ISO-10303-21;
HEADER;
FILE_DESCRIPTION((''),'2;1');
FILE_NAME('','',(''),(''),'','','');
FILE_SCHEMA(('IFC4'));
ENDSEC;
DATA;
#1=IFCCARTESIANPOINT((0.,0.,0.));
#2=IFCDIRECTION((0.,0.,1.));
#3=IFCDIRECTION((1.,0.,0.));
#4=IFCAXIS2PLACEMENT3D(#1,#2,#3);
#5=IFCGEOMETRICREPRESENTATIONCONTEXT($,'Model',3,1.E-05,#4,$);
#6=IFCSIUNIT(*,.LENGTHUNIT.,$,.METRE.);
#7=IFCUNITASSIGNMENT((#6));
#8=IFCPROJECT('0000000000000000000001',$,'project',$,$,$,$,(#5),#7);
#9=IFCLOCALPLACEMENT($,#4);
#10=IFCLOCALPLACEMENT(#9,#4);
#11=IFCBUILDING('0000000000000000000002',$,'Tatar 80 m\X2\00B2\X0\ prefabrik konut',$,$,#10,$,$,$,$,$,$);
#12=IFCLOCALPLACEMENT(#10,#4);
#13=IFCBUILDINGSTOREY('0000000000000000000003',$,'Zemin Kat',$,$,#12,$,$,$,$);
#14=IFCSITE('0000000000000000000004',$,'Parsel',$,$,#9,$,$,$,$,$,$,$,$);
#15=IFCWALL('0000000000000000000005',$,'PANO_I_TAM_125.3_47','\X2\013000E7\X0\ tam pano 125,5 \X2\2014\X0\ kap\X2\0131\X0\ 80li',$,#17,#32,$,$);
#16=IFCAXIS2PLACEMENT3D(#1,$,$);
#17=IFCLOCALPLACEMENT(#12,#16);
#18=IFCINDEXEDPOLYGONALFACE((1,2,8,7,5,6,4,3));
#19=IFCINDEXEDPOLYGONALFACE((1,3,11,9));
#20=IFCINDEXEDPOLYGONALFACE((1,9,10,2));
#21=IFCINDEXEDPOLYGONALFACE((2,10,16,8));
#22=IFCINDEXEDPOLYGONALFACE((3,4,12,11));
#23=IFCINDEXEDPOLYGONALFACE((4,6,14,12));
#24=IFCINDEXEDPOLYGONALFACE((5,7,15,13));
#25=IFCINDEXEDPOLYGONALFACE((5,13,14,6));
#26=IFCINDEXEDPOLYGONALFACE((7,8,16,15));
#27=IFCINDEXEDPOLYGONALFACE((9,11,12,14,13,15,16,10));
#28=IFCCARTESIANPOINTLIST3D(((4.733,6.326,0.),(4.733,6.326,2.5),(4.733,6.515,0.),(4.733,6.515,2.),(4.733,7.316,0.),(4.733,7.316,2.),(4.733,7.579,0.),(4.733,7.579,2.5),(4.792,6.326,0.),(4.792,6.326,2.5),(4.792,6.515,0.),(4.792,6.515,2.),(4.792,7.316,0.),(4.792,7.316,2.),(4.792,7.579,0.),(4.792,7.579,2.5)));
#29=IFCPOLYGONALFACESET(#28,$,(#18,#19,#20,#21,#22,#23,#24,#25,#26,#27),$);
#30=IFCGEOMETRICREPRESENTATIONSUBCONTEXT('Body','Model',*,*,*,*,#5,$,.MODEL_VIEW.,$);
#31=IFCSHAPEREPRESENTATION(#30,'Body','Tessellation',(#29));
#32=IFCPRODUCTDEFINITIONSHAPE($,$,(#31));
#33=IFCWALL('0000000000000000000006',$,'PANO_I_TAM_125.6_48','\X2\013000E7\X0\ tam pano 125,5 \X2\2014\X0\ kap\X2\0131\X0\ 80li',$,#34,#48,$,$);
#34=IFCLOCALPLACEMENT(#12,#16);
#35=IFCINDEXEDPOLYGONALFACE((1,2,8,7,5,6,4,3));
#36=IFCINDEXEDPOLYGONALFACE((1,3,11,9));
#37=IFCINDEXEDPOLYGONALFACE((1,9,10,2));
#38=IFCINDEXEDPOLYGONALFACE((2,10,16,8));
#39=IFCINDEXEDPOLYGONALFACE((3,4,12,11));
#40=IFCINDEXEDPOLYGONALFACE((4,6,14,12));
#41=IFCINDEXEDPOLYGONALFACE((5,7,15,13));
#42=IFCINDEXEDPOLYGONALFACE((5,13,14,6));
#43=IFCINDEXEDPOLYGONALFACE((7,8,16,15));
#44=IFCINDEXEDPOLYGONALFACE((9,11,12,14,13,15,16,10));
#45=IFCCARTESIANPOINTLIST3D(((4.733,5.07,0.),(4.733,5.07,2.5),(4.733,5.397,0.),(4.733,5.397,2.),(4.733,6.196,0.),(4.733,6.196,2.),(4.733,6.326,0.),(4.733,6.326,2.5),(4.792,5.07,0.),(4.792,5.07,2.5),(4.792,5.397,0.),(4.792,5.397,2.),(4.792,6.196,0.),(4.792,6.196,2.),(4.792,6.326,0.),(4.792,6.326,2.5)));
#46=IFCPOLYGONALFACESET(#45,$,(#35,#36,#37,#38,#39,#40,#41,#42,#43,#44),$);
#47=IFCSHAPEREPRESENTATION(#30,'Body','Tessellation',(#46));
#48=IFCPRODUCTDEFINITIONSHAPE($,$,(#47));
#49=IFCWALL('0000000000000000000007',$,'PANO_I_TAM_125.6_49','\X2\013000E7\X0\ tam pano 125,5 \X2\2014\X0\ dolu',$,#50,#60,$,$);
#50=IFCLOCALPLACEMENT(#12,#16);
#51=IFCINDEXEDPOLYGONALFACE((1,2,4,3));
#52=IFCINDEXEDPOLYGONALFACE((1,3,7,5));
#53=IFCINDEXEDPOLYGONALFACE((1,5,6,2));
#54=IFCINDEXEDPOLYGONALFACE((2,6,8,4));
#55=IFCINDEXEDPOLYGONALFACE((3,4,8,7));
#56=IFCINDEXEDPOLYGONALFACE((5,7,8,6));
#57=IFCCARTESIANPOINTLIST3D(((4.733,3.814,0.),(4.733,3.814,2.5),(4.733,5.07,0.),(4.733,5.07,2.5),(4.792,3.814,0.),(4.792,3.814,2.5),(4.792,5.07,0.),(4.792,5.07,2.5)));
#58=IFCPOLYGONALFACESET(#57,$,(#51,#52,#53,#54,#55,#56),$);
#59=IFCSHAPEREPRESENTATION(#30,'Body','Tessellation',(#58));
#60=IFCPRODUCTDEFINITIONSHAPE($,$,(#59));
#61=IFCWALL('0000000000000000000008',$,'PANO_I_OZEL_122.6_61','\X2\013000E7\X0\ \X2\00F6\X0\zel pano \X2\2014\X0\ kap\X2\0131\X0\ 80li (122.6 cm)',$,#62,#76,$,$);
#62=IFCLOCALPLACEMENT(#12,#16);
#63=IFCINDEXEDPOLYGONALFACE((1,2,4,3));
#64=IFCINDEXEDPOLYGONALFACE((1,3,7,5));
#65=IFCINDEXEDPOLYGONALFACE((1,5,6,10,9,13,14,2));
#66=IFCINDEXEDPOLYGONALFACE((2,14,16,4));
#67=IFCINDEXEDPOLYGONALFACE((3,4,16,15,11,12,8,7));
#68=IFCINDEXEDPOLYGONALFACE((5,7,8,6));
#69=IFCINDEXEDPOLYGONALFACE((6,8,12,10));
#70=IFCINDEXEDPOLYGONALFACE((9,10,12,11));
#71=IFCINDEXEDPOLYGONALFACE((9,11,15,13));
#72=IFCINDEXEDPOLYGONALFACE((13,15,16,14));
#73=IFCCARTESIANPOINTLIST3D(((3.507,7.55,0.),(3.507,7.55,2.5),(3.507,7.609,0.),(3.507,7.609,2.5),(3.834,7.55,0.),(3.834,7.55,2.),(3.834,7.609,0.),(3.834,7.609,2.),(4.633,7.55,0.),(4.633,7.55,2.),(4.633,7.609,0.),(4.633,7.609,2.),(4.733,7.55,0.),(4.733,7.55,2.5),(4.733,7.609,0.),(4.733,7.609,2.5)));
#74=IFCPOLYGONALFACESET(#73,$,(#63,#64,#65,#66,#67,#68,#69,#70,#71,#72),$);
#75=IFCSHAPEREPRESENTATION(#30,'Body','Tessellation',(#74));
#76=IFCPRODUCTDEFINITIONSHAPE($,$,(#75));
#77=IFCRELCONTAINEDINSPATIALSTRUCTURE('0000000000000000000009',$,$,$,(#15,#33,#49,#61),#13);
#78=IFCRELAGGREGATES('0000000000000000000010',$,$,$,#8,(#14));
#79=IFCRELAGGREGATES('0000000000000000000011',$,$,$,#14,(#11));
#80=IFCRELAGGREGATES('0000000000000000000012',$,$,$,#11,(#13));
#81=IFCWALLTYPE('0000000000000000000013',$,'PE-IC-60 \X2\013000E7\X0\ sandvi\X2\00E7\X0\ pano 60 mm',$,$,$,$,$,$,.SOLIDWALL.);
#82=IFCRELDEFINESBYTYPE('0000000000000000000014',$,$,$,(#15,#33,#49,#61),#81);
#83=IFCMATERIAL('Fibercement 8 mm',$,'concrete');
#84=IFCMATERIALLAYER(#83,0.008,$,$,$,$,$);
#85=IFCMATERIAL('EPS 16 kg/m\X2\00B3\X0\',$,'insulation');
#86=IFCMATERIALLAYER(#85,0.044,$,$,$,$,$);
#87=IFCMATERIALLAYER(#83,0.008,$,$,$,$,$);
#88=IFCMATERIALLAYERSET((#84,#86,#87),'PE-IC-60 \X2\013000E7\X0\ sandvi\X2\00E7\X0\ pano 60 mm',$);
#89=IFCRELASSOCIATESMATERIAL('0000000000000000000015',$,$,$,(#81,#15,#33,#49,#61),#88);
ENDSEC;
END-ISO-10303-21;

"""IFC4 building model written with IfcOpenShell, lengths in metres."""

from ifc_helpers import new_model, si_unit, frame, origin_with_axes, place, context, subcontext, project, spatial, line, indexed_curve, outline, extrude, material, layer, layer_set, layer_usage, type_object, element, save


model = new_model("IFC4")

# Units and contexts
model_context = context("Model", 3, precision=1e-05, world=origin_with_axes())
body_context = subcontext(model_context, "Body", "Model", "MODEL_VIEW")
ifc_project = project(units=[si_unit("LENGTHUNIT", "METRE")], contexts=[model_context])

# Site, building, storey
site_placement = place(None, origin_with_axes())
site = spatial("IfcSite", under=ifc_project, at=site_placement, Name="Parsel")
building_placement = place(site_placement, origin_with_axes())
building = spatial("IfcBuilding", under=site, at=building_placement, Name="Tatar 80 m² prefabrik konut")
storey_placement = place(building_placement, origin_with_axes())
storey = spatial("IfcBuildingStorey", under=building, at=storey_placement, Name="Zemin Kat")

# Shared definitions
ifc_material_1 = material(Name="Fibercement 8 mm", Category="concrete")
ifc_material_2 = material(Name="EPS 16 kg/m³", Category="insulation")

# Shared definitions
ifc_layer_1 = layer(ifc_material_1, 0.008)
ifc_layer_2 = layer(ifc_material_2, 0.044)
ifc_layer_3 = layer(ifc_material_1, 0.008)
ifc_layer_set_1 = layer_set([ifc_layer_1, ifc_layer_2, ifc_layer_3], Name="PE-IC-60 İç sandviç pano 60 mm")
wall_type_1 = type_object("IfcWallType", Name="PE-IC-60 İç sandviç pano 60 mm", PredefinedType="SOLIDWALL", material=ifc_layer_set_1)

# Walls, openings
ifc_layer_usage_1 = layer_usage(ifc_layer_set_1, "AXIS2", "POSITIVE", 0.0)
wall_1_placement = place(storey_placement, frame((4.792, 6.326, 0.0), z_axis=(0.0, 0.0, 1.0), x_axis=(0.0, 1.0, 0.0)))
wall_1 = element("IfcWall", 1, at=wall_1_placement, inside=storey, type_object=wall_type_1, material=ifc_layer_usage_1, Name="PANO_I_TAM_125.3_47", Description="İç tam pano 125,5 — kapı 80li", context=body_context, shape_type="SweptSolid", body=[
    extrude(outline(indexed_curve([(0.0, 0.0), (1.253, 0.0), (1.253, 0.059), (0.0, 0.059)], segments=[line(1, 2, 3, 4, 1)])), origin_with_axes(), (0.0, 0.0, 1.0), 2.5),
])
opening_1_placement = place(wall_1_placement, origin_with_axes())
element("IfcOpeningElement", 2, at=opening_1_placement, cuts=wall_1, PredefinedType="OPENING", context=body_context, shape_type="SweptSolid", body=[
    extrude(outline(indexed_curve([(0.0, 0.0), (0.801, 0.0), (0.801, 0.099), (0.0, 0.099)], segments=[line(1, 2, 3, 4, 1)])), frame((0.189, -0.02, 0.0), z_axis=(0.0, 0.0, 1.0), x_axis=(1.0, 0.0, 0.0)), (0.0, 0.0, 1.0), 2.0),
])
ifc_layer_usage_2 = layer_usage(ifc_layer_set_1, "AXIS2", "POSITIVE", 0.0)
wall_2_placement = place(storey_placement, frame((4.792, 5.07, 0.0), z_axis=(0.0, 0.0, 1.0), x_axis=(0.0, 1.0, 0.0)))
wall_2 = element("IfcWall", 3, at=wall_2_placement, inside=storey, type_object=wall_type_1, material=ifc_layer_usage_2, Name="PANO_I_TAM_125.6_48", Description="İç tam pano 125,5 — kapı 80li", context=body_context, shape_type="SweptSolid", body=[
    extrude(outline(indexed_curve([(0.0, 0.0), (1.256, 0.0), (1.256, 0.059), (0.0, 0.059)], segments=[line(1, 2, 3, 4, 1)])), origin_with_axes(), (0.0, 0.0, 1.0), 2.5),
])
opening_2_placement = place(wall_2_placement, origin_with_axes())
element("IfcOpeningElement", 4, at=opening_2_placement, cuts=wall_2, PredefinedType="OPENING", context=body_context, shape_type="SweptSolid", body=[
    extrude(outline(indexed_curve([(0.0, 0.0), (0.799, 0.0), (0.799, 0.099), (0.0, 0.099)], segments=[line(1, 2, 3, 4, 1)])), frame((0.327, -0.02, 0.0), z_axis=(0.0, 0.0, 1.0), x_axis=(1.0, 0.0, 0.0)), (0.0, 0.0, 1.0), 2.0),
])

# Wall
ifc_layer_usage_3 = layer_usage(ifc_layer_set_1, "AXIS2", "POSITIVE", 0.0)
wall_3_placement = place(storey_placement, frame((4.792, 3.814, 0.0), z_axis=(0.0, 0.0, 1.0), x_axis=(0.0, 1.0, 0.0)))
element("IfcWall", 5, at=wall_3_placement, inside=storey, type_object=wall_type_1, material=ifc_layer_usage_3, Name="PANO_I_TAM_125.6_49", Description="İç tam pano 125,5 — dolu", context=body_context, shape_type="SweptSolid", body=[
    extrude(outline(indexed_curve([(0.0, 0.0), (1.256, 0.0), (1.256, 0.059), (0.0, 0.059)], segments=[line(1, 2, 3, 4, 1)])), origin_with_axes(), (0.0, 0.0, 1.0), 2.5),
])

# Wall, opening
ifc_layer_usage_4 = layer_usage(ifc_layer_set_1, "AXIS2", "POSITIVE", 0.0)
wall_4_placement = place(storey_placement, frame((3.507, 7.55, 0.0), z_axis=(0.0, 0.0, 1.0), x_axis=(1.0, 0.0, 0.0)))
wall_4 = element("IfcWall", 6, at=wall_4_placement, inside=storey, type_object=wall_type_1, material=ifc_layer_usage_4, Name="PANO_I_OZEL_122.6_61", Description="İç özel pano — kapı 80li (122.6 cm)", context=body_context, shape_type="SweptSolid", body=[
    extrude(outline(indexed_curve([(0.0, 0.0), (1.226, 0.0), (1.226, 0.059), (0.0, 0.059)], segments=[line(1, 2, 3, 4, 1)])), origin_with_axes(), (0.0, 0.0, 1.0), 2.5),
])
opening_3_placement = place(wall_4_placement, origin_with_axes())
element("IfcOpeningElement", 7, at=opening_3_placement, cuts=wall_4, PredefinedType="OPENING", context=body_context, shape_type="SweptSolid", body=[
    extrude(outline(indexed_curve([(0.0, 0.0), (0.799, 0.0), (0.799, 0.099), (0.0, 0.099)], segments=[line(1, 2, 3, 4, 1)])), frame((0.327, -0.02, 0.0), z_axis=(0.0, 0.0, 1.0), x_axis=(1.0, 0.0, 0.0)), (0.0, 0.0, 1.0), 2.0),
])

save(model, "model.ifc")
